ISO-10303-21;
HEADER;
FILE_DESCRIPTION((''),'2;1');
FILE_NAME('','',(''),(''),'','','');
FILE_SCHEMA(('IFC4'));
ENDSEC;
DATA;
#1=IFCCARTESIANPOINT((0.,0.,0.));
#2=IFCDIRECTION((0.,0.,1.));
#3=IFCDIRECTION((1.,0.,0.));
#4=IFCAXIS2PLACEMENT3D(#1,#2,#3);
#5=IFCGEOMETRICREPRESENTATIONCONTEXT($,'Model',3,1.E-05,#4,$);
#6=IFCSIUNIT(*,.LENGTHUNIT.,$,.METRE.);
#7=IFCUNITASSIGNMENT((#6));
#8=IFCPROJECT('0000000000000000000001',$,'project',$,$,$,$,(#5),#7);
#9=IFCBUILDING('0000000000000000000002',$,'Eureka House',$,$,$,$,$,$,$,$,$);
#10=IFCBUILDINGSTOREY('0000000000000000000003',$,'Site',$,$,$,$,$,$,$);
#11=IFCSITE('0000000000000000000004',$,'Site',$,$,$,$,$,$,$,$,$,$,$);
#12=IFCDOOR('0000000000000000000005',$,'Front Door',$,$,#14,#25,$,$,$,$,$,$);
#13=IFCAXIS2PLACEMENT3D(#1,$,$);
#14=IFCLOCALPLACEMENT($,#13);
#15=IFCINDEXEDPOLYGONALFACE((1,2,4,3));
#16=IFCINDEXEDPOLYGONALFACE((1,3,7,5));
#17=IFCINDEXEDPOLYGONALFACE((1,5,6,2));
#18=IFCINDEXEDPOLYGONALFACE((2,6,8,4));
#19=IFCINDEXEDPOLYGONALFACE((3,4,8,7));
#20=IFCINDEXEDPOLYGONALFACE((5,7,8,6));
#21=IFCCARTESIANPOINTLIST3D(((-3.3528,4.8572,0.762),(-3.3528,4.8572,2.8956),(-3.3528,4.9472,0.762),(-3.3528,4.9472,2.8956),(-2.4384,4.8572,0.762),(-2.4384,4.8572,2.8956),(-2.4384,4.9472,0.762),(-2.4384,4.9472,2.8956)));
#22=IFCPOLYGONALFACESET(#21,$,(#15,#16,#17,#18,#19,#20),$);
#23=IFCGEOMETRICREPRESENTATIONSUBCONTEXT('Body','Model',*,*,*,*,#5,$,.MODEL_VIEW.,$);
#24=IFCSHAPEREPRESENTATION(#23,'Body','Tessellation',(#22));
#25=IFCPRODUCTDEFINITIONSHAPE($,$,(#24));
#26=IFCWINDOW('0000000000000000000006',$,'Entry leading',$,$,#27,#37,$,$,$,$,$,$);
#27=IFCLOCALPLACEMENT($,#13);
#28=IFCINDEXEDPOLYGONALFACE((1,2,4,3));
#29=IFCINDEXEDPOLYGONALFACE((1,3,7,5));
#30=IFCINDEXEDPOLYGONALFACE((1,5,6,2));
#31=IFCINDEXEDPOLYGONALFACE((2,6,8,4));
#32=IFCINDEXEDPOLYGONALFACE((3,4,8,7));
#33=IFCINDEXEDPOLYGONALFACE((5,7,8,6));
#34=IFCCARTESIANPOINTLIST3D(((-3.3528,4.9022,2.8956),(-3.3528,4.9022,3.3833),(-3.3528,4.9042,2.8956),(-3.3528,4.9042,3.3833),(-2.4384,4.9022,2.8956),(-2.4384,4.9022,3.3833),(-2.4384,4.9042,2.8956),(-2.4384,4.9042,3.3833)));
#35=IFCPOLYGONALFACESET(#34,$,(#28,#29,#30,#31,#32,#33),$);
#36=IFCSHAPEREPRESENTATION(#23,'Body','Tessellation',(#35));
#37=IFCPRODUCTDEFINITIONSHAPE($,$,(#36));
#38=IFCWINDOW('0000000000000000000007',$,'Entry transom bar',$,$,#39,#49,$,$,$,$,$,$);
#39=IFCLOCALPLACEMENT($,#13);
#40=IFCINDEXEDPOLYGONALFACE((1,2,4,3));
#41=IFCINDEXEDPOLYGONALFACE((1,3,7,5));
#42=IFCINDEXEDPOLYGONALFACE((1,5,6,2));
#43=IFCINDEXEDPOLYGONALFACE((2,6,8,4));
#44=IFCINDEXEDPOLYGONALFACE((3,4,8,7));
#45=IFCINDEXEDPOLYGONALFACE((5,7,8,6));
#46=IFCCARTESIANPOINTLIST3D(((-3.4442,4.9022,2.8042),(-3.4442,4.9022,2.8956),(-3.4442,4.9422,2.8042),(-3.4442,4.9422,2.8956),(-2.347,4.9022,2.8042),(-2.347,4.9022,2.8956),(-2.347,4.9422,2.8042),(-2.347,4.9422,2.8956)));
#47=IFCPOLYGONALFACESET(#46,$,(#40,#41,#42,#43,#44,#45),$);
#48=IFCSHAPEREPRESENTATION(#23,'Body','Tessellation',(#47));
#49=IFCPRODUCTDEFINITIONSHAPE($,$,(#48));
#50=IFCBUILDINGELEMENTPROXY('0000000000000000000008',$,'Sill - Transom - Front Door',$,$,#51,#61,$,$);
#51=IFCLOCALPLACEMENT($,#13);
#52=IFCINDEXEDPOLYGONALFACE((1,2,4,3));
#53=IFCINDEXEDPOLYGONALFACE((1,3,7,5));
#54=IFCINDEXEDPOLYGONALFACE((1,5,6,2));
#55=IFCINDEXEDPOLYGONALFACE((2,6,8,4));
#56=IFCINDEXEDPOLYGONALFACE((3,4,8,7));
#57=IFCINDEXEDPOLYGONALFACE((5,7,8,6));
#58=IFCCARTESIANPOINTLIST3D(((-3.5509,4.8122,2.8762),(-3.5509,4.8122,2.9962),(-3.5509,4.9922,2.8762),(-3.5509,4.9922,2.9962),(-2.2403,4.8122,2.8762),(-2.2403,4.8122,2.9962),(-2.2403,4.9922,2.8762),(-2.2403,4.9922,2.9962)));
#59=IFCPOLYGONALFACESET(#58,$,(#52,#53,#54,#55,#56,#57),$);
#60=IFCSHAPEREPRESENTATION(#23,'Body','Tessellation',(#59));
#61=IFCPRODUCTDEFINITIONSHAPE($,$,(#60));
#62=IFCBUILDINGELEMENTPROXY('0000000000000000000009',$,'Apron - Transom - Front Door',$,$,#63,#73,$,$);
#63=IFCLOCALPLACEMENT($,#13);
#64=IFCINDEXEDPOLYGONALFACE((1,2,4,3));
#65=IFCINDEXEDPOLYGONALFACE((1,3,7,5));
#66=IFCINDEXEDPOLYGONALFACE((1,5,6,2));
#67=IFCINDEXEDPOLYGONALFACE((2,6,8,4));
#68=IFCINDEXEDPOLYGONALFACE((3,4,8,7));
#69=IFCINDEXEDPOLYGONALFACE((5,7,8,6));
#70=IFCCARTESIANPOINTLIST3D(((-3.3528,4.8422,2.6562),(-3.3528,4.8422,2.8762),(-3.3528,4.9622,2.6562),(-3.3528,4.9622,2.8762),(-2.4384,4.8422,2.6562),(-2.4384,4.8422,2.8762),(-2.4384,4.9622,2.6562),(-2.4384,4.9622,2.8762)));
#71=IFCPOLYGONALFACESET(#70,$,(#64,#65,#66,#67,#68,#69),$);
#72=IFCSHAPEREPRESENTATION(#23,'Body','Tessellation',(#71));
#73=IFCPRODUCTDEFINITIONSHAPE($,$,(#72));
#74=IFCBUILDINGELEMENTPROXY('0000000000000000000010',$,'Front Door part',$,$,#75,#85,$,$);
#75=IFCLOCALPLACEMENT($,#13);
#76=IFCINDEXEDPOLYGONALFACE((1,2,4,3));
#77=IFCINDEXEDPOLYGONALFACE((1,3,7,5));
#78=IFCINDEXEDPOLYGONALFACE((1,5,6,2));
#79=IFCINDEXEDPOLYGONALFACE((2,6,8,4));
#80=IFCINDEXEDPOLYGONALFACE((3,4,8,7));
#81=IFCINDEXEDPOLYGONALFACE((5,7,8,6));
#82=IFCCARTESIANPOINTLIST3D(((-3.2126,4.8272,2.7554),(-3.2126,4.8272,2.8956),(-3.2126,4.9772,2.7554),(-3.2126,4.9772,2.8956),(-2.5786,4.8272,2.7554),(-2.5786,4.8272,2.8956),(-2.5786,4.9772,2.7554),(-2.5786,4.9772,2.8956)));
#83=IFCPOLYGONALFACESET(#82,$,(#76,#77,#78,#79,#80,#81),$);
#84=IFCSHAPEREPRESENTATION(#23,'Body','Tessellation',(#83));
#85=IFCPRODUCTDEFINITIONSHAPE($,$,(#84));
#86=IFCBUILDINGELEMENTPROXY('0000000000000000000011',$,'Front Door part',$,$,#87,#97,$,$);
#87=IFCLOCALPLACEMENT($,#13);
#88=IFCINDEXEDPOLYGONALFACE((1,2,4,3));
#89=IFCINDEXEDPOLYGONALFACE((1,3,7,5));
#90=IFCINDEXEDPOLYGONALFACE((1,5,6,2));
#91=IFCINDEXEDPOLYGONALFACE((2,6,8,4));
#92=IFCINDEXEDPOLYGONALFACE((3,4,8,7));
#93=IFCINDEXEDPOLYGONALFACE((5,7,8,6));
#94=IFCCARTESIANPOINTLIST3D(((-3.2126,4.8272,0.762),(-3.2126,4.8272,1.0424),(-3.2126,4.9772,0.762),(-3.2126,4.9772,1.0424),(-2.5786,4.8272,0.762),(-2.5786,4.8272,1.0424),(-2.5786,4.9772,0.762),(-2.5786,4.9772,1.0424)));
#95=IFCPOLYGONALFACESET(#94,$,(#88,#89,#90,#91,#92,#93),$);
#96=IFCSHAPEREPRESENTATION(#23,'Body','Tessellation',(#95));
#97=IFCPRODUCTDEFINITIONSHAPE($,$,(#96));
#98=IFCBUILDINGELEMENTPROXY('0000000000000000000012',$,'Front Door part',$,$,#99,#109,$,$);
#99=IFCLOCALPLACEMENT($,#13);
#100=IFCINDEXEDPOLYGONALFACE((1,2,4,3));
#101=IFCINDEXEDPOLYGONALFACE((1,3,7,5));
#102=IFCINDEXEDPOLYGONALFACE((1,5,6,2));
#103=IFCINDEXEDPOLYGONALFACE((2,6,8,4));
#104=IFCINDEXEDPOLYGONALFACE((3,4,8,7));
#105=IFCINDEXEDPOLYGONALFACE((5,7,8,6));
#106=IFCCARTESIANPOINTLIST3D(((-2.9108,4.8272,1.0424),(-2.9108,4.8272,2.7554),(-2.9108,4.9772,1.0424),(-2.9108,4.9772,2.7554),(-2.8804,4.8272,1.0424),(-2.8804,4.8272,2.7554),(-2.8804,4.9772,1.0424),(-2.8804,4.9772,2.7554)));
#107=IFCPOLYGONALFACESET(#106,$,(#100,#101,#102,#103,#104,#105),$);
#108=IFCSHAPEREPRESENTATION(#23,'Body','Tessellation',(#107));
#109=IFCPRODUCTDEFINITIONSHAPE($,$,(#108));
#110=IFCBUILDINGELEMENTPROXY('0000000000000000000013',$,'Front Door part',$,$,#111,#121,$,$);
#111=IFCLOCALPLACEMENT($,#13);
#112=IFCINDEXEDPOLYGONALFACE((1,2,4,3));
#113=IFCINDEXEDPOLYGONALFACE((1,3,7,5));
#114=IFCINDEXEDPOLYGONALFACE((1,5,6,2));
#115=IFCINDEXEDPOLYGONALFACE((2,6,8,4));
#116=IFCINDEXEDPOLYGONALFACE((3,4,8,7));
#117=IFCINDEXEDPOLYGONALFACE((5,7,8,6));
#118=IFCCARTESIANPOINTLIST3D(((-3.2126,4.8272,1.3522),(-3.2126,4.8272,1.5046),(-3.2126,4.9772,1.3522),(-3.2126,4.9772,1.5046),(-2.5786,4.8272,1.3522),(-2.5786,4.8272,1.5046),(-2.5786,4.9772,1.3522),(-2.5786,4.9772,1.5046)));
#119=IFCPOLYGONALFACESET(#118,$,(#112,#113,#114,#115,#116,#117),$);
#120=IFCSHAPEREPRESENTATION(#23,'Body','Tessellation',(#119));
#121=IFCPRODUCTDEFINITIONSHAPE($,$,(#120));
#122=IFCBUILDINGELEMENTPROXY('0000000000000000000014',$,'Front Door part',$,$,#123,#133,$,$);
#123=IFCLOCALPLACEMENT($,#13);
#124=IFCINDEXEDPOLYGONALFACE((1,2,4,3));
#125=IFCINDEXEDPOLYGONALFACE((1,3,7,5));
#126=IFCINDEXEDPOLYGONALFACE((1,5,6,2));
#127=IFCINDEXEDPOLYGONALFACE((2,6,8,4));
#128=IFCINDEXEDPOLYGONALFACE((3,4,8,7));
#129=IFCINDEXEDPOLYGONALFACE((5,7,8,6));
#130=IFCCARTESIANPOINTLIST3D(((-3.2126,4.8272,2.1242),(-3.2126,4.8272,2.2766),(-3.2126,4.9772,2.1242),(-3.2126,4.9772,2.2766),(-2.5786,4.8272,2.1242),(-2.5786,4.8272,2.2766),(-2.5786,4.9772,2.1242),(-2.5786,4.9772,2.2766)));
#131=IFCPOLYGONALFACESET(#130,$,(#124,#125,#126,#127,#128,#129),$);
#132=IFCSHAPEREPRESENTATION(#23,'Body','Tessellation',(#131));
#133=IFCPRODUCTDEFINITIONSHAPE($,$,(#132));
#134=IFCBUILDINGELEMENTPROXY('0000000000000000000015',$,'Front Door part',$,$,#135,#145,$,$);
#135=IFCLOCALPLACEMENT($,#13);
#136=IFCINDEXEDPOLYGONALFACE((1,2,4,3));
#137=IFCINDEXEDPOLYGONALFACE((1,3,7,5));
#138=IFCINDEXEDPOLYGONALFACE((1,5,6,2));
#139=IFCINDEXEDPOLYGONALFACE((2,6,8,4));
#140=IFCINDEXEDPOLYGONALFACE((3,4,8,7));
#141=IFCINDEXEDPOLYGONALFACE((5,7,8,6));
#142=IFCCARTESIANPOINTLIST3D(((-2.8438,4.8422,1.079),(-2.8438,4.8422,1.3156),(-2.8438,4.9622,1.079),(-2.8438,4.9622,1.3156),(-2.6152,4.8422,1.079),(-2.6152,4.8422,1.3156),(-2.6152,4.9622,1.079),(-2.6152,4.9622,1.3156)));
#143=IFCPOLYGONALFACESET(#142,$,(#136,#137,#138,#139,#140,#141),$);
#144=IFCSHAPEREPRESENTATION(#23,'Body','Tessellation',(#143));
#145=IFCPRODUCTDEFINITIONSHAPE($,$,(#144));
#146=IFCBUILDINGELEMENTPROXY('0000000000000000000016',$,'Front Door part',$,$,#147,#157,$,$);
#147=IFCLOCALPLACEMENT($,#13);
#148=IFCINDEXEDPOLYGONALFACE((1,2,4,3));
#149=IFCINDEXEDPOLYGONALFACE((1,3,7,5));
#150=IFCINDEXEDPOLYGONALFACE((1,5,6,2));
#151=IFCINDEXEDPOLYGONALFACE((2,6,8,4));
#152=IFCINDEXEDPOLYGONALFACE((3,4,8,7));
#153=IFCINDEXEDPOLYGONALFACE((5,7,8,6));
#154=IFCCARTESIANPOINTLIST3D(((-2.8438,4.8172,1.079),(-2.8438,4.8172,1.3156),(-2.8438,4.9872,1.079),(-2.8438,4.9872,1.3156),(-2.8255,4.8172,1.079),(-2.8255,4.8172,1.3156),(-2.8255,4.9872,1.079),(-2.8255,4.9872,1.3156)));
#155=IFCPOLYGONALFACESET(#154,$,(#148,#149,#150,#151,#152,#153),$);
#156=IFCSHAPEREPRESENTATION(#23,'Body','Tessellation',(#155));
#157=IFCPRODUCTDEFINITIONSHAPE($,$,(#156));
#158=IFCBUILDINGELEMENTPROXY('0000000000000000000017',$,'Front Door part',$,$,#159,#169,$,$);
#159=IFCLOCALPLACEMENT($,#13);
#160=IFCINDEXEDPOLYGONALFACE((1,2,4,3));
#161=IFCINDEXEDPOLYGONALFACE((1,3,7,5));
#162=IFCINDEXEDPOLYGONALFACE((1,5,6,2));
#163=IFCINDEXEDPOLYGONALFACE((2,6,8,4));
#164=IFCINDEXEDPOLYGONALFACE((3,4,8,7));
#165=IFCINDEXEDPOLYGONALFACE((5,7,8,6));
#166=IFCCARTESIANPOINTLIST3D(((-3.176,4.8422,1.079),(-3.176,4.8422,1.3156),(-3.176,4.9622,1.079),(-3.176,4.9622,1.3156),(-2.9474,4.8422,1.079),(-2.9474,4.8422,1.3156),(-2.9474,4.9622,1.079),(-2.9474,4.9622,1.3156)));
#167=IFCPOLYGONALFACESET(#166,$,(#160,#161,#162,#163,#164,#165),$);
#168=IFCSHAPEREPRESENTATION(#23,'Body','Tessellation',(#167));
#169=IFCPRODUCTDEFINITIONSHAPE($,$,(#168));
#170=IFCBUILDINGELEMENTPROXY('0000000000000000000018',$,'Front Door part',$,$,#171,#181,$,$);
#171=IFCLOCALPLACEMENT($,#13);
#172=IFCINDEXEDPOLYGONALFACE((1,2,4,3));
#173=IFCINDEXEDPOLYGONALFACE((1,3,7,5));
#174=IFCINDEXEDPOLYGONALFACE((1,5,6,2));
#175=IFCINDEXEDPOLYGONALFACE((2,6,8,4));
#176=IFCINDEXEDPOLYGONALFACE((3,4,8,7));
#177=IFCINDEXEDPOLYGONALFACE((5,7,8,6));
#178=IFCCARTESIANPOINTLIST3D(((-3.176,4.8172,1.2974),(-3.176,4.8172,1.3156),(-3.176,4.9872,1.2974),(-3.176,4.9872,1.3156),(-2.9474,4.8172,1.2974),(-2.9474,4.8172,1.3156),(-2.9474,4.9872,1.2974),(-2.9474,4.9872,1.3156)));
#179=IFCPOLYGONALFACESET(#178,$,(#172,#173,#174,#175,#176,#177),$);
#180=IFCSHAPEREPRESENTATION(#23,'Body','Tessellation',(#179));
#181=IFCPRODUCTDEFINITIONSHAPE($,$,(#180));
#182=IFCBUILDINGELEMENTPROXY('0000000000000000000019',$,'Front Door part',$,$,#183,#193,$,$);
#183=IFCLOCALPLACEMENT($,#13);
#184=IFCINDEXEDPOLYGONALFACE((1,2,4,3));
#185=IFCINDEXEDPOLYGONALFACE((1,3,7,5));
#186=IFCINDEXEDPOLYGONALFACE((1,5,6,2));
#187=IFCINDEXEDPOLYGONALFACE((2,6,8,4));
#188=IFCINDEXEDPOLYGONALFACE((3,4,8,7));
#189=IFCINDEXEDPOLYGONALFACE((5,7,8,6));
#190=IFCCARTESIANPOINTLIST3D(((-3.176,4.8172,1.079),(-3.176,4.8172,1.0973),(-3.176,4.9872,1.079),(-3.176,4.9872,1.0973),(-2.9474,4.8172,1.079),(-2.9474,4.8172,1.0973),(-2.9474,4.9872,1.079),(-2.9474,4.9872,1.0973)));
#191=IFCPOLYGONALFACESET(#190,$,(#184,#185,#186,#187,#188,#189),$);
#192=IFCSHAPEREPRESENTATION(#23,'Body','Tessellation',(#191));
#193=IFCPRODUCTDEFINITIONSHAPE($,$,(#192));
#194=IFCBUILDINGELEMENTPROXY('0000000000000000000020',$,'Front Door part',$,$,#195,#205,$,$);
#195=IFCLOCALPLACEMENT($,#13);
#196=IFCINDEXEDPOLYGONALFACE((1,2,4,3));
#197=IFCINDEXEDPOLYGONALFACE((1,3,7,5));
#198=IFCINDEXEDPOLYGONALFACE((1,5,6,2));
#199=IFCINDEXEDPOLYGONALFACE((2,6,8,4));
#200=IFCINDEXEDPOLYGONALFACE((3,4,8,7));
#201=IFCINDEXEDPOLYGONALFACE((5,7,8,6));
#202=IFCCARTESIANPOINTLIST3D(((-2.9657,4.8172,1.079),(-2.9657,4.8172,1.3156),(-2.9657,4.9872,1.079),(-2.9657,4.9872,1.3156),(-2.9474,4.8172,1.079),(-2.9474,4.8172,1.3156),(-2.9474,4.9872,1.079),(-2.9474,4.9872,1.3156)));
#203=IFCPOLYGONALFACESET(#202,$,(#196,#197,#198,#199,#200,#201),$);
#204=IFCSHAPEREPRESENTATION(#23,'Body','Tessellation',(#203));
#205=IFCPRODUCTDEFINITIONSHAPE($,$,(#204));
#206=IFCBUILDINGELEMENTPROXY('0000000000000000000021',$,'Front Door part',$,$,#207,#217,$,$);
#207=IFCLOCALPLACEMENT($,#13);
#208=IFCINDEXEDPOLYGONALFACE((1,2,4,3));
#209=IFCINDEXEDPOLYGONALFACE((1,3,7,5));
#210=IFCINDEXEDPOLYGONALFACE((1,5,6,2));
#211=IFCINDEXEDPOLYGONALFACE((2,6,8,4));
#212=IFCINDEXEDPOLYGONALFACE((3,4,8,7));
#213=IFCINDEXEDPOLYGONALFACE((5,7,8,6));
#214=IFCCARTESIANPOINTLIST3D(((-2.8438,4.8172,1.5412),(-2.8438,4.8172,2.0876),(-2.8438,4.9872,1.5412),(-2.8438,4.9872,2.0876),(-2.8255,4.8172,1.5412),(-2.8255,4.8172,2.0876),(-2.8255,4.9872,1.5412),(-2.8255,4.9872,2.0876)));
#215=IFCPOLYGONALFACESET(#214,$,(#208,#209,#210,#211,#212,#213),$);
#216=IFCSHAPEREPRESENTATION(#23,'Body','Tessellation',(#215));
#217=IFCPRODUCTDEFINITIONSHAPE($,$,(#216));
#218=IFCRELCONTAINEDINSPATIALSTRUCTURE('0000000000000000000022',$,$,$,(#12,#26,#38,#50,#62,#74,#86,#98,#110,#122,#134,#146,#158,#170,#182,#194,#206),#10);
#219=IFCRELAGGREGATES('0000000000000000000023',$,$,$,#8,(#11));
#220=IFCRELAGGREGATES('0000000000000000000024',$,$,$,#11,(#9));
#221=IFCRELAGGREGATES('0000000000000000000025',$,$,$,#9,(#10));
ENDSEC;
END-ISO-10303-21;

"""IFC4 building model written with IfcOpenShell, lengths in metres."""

from ifc_helpers import new_model, si_unit, frame, origin, origin_with_axes, origin_2d, place, context, subcontext, project, spatial, rectangle, extrude, element, save


model = new_model("IFC4")

# Units and contexts
model_context = context("Model", 3, precision=1e-05, world=origin_with_axes())
body_context = subcontext(model_context, "Body", "Model", "MODEL_VIEW")
ifc_project = project(units=[si_unit("LENGTHUNIT", "METRE")], contexts=[model_context])

# Site, building, storey
site = spatial("IfcSite", under=ifc_project, Name="Site")
building = spatial("IfcBuilding", under=site, Name="Eureka House")
storey = spatial("IfcBuildingStorey", under=building, Name="Site")

# Door
door_placement = place(None, frame((-2.8956, 4.9022, 0.762), z_axis=(0.0, 0.0, 1.0), x_axis=(1.0, 0.0, 0.0)))
element("IfcDoor", 1, at=door_placement, inside=storey, Name="Front Door", context=body_context, shape_type="SweptSolid", body=[
    extrude(rectangle(XDim=0.9144, YDim=0.09, at=origin_2d()), origin(), (0.0, 0.0, 1.0), 2.1336),
])

# Windows
window_1_placement = place(None, frame((-2.8956, 4.9032, 2.8956), z_axis=(0.0, 0.0, 1.0), x_axis=(1.0, 0.0, 0.0)))
element("IfcWindow", 2, at=window_1_placement, inside=storey, Name="Entry leading", context=body_context, shape_type="SweptSolid", body=[
    extrude(rectangle(XDim=0.9144, YDim=0.002, at=origin_2d()), origin(), (0.0, 0.0, 1.0), 0.4877),
])
window_2_placement = place(None, frame((-2.8956, 4.9222, 2.8042), z_axis=(0.0, 0.0, 1.0), x_axis=(1.0, 0.0, 0.0)))
element("IfcWindow", 3, at=window_2_placement, inside=storey, Name="Entry transom bar", context=body_context, shape_type="SweptSolid", body=[
    extrude(rectangle(XDim=1.0973, YDim=0.04, at=origin_2d()), origin(), (0.0, 0.0, 1.0), 0.0914),
])

# Building element proxies
proxy_1_placement = place(None, frame((-2.8956, 4.9022, 2.8762), z_axis=(0.0, 0.0, 1.0), x_axis=(1.0, 0.0, 0.0)))
element("IfcBuildingElementProxy", 4, at=proxy_1_placement, inside=storey, Name="Sill - Transom - Front Door", context=body_context, shape_type="SweptSolid", body=[
    extrude(rectangle(XDim=1.3106, YDim=0.18, at=origin_2d()), origin(), (0.0, 0.0, 1.0), 0.12),
])
proxy_2_placement = place(None, frame((-2.8956, 4.9022, 2.6562), z_axis=(0.0, 0.0, 1.0), x_axis=(1.0, 0.0, 0.0)))
element("IfcBuildingElementProxy", 5, at=proxy_2_placement, inside=storey, Name="Apron - Transom - Front Door", context=body_context, shape_type="SweptSolid", body=[
    extrude(rectangle(XDim=0.9144, YDim=0.12, at=origin_2d()), origin(), (0.0, 0.0, 1.0), 0.22),
])
proxy_3_placement = place(None, frame((-2.8956, 4.9022, 2.7554), z_axis=(0.0, 0.0, 1.0), x_axis=(1.0, 0.0, 0.0)))
element("IfcBuildingElementProxy", 6, at=proxy_3_placement, inside=storey, Name="Front Door part", context=body_context, shape_type="SweptSolid", body=[
    extrude(rectangle(XDim=0.634, YDim=0.15, at=origin_2d()), origin(), (0.0, 0.0, 1.0), 0.1402),
])
proxy_4_placement = place(None, frame((-2.8956, 4.9022, 0.762), z_axis=(0.0, 0.0, 1.0), x_axis=(1.0, 0.0, 0.0)))
element("IfcBuildingElementProxy", 7, at=proxy_4_placement, inside=storey, Name="Front Door part", context=body_context, shape_type="SweptSolid", body=[
    extrude(rectangle(XDim=0.634, YDim=0.15, at=origin_2d()), origin(), (0.0, 0.0, 1.0), 0.2804),
])
proxy_5_placement = place(None, frame((-2.8956, 4.9022, 1.0424), z_axis=(0.0, 0.0, 1.0), x_axis=(1.0, 0.0, 0.0)))
element("IfcBuildingElementProxy", 8, at=proxy_5_placement, inside=storey, Name="Front Door part", context=body_context, shape_type="SweptSolid", body=[
    extrude(rectangle(XDim=0.0305, YDim=0.15, at=origin_2d()), origin(), (0.0, 0.0, 1.0), 1.713),
])
for number, where, z_axis, x_axis, name in (
    (9, (-2.8956, 4.9022, 1.3522), (0.0, 0.0, 1.0), (1.0, 0.0, 0.0), "Front Door part"),
    (10, (-2.8956, 4.9022, 2.1242), (0.0, 0.0, 1.0), (1.0, 0.0, 0.0), "Front Door part"),
):
    element("IfcBuildingElementProxy", number, at=place(None, frame(where, z_axis=z_axis, x_axis=x_axis)), inside=storey, Name=name, context=body_context, shape_type="SweptSolid", body=[
        extrude(rectangle(XDim=0.634, YDim=0.15, at=origin_2d()), origin(), (0.0, 0.0, 1.0), 0.1524),
    ])
proxy_6_placement = place(None, frame((-2.7295, 4.9022, 1.079), z_axis=(0.0, 0.0, 1.0), x_axis=(1.0, 0.0, 0.0)))
element("IfcBuildingElementProxy", 11, at=proxy_6_placement, inside=storey, Name="Front Door part", context=body_context, shape_type="SweptSolid", body=[
    extrude(rectangle(XDim=0.2286, YDim=0.12, at=origin_2d()), origin(), (0.0, 0.0, 1.0), 0.2366),
])
proxy_7_placement = place(None, frame((-2.8346, 4.9022, 1.079), z_axis=(0.0, 0.0, 1.0), x_axis=(1.0, 0.0, 0.0)))
element("IfcBuildingElementProxy", 12, at=proxy_7_placement, inside=storey, Name="Front Door part", context=body_context, shape_type="SweptSolid", body=[
    extrude(rectangle(XDim=0.0183, YDim=0.17, at=origin_2d()), origin(), (0.0, 0.0, 1.0), 0.2366),
])
proxy_8_placement = place(None, frame((-3.0617, 4.9022, 1.079), z_axis=(0.0, 0.0, 1.0), x_axis=(1.0, 0.0, 0.0)))
element("IfcBuildingElementProxy", 13, at=proxy_8_placement, inside=storey, Name="Front Door part", context=body_context, shape_type="SweptSolid", body=[
    extrude(rectangle(XDim=0.2286, YDim=0.12, at=origin_2d()), origin(), (0.0, 0.0, 1.0), 0.2366),
])
for number, where, z_axis, x_axis, name in (
    (14, (-3.0617, 4.9022, 1.2974), (0.0, 0.0, 1.0), (1.0, 0.0, 0.0), "Front Door part"),
    (15, (-3.0617, 4.9022, 1.079), (0.0, 0.0, 1.0), (1.0, 0.0, 0.0), "Front Door part"),
):
    element("IfcBuildingElementProxy", number, at=place(None, frame(where, z_axis=z_axis, x_axis=x_axis)), inside=storey, Name=name, context=body_context, shape_type="SweptSolid", body=[
        extrude(rectangle(XDim=0.2286, YDim=0.17, at=origin_2d()), origin(), (0.0, 0.0, 1.0), 0.0183),
    ])
proxy_9_placement = place(None, frame((-2.9566, 4.9022, 1.079), z_axis=(0.0, 0.0, 1.0), x_axis=(1.0, 0.0, 0.0)))
element("IfcBuildingElementProxy", 16, at=proxy_9_placement, inside=storey, Name="Front Door part", context=body_context, shape_type="SweptSolid", body=[
    extrude(rectangle(XDim=0.0183, YDim=0.17, at=origin_2d()), origin(), (0.0, 0.0, 1.0), 0.2366),
])
proxy_10_placement = place(None, frame((-2.8346, 4.9022, 1.5412), z_axis=(0.0, 0.0, 1.0), x_axis=(1.0, 0.0, 0.0)))
element("IfcBuildingElementProxy", 17, at=proxy_10_placement, inside=storey, Name="Front Door part", context=body_context, shape_type="SweptSolid", body=[
    extrude(rectangle(XDim=0.0183, YDim=0.17, at=origin_2d()), origin(), (0.0, 0.0, 1.0), 0.5464),
])

save(model, "model.ifc")
